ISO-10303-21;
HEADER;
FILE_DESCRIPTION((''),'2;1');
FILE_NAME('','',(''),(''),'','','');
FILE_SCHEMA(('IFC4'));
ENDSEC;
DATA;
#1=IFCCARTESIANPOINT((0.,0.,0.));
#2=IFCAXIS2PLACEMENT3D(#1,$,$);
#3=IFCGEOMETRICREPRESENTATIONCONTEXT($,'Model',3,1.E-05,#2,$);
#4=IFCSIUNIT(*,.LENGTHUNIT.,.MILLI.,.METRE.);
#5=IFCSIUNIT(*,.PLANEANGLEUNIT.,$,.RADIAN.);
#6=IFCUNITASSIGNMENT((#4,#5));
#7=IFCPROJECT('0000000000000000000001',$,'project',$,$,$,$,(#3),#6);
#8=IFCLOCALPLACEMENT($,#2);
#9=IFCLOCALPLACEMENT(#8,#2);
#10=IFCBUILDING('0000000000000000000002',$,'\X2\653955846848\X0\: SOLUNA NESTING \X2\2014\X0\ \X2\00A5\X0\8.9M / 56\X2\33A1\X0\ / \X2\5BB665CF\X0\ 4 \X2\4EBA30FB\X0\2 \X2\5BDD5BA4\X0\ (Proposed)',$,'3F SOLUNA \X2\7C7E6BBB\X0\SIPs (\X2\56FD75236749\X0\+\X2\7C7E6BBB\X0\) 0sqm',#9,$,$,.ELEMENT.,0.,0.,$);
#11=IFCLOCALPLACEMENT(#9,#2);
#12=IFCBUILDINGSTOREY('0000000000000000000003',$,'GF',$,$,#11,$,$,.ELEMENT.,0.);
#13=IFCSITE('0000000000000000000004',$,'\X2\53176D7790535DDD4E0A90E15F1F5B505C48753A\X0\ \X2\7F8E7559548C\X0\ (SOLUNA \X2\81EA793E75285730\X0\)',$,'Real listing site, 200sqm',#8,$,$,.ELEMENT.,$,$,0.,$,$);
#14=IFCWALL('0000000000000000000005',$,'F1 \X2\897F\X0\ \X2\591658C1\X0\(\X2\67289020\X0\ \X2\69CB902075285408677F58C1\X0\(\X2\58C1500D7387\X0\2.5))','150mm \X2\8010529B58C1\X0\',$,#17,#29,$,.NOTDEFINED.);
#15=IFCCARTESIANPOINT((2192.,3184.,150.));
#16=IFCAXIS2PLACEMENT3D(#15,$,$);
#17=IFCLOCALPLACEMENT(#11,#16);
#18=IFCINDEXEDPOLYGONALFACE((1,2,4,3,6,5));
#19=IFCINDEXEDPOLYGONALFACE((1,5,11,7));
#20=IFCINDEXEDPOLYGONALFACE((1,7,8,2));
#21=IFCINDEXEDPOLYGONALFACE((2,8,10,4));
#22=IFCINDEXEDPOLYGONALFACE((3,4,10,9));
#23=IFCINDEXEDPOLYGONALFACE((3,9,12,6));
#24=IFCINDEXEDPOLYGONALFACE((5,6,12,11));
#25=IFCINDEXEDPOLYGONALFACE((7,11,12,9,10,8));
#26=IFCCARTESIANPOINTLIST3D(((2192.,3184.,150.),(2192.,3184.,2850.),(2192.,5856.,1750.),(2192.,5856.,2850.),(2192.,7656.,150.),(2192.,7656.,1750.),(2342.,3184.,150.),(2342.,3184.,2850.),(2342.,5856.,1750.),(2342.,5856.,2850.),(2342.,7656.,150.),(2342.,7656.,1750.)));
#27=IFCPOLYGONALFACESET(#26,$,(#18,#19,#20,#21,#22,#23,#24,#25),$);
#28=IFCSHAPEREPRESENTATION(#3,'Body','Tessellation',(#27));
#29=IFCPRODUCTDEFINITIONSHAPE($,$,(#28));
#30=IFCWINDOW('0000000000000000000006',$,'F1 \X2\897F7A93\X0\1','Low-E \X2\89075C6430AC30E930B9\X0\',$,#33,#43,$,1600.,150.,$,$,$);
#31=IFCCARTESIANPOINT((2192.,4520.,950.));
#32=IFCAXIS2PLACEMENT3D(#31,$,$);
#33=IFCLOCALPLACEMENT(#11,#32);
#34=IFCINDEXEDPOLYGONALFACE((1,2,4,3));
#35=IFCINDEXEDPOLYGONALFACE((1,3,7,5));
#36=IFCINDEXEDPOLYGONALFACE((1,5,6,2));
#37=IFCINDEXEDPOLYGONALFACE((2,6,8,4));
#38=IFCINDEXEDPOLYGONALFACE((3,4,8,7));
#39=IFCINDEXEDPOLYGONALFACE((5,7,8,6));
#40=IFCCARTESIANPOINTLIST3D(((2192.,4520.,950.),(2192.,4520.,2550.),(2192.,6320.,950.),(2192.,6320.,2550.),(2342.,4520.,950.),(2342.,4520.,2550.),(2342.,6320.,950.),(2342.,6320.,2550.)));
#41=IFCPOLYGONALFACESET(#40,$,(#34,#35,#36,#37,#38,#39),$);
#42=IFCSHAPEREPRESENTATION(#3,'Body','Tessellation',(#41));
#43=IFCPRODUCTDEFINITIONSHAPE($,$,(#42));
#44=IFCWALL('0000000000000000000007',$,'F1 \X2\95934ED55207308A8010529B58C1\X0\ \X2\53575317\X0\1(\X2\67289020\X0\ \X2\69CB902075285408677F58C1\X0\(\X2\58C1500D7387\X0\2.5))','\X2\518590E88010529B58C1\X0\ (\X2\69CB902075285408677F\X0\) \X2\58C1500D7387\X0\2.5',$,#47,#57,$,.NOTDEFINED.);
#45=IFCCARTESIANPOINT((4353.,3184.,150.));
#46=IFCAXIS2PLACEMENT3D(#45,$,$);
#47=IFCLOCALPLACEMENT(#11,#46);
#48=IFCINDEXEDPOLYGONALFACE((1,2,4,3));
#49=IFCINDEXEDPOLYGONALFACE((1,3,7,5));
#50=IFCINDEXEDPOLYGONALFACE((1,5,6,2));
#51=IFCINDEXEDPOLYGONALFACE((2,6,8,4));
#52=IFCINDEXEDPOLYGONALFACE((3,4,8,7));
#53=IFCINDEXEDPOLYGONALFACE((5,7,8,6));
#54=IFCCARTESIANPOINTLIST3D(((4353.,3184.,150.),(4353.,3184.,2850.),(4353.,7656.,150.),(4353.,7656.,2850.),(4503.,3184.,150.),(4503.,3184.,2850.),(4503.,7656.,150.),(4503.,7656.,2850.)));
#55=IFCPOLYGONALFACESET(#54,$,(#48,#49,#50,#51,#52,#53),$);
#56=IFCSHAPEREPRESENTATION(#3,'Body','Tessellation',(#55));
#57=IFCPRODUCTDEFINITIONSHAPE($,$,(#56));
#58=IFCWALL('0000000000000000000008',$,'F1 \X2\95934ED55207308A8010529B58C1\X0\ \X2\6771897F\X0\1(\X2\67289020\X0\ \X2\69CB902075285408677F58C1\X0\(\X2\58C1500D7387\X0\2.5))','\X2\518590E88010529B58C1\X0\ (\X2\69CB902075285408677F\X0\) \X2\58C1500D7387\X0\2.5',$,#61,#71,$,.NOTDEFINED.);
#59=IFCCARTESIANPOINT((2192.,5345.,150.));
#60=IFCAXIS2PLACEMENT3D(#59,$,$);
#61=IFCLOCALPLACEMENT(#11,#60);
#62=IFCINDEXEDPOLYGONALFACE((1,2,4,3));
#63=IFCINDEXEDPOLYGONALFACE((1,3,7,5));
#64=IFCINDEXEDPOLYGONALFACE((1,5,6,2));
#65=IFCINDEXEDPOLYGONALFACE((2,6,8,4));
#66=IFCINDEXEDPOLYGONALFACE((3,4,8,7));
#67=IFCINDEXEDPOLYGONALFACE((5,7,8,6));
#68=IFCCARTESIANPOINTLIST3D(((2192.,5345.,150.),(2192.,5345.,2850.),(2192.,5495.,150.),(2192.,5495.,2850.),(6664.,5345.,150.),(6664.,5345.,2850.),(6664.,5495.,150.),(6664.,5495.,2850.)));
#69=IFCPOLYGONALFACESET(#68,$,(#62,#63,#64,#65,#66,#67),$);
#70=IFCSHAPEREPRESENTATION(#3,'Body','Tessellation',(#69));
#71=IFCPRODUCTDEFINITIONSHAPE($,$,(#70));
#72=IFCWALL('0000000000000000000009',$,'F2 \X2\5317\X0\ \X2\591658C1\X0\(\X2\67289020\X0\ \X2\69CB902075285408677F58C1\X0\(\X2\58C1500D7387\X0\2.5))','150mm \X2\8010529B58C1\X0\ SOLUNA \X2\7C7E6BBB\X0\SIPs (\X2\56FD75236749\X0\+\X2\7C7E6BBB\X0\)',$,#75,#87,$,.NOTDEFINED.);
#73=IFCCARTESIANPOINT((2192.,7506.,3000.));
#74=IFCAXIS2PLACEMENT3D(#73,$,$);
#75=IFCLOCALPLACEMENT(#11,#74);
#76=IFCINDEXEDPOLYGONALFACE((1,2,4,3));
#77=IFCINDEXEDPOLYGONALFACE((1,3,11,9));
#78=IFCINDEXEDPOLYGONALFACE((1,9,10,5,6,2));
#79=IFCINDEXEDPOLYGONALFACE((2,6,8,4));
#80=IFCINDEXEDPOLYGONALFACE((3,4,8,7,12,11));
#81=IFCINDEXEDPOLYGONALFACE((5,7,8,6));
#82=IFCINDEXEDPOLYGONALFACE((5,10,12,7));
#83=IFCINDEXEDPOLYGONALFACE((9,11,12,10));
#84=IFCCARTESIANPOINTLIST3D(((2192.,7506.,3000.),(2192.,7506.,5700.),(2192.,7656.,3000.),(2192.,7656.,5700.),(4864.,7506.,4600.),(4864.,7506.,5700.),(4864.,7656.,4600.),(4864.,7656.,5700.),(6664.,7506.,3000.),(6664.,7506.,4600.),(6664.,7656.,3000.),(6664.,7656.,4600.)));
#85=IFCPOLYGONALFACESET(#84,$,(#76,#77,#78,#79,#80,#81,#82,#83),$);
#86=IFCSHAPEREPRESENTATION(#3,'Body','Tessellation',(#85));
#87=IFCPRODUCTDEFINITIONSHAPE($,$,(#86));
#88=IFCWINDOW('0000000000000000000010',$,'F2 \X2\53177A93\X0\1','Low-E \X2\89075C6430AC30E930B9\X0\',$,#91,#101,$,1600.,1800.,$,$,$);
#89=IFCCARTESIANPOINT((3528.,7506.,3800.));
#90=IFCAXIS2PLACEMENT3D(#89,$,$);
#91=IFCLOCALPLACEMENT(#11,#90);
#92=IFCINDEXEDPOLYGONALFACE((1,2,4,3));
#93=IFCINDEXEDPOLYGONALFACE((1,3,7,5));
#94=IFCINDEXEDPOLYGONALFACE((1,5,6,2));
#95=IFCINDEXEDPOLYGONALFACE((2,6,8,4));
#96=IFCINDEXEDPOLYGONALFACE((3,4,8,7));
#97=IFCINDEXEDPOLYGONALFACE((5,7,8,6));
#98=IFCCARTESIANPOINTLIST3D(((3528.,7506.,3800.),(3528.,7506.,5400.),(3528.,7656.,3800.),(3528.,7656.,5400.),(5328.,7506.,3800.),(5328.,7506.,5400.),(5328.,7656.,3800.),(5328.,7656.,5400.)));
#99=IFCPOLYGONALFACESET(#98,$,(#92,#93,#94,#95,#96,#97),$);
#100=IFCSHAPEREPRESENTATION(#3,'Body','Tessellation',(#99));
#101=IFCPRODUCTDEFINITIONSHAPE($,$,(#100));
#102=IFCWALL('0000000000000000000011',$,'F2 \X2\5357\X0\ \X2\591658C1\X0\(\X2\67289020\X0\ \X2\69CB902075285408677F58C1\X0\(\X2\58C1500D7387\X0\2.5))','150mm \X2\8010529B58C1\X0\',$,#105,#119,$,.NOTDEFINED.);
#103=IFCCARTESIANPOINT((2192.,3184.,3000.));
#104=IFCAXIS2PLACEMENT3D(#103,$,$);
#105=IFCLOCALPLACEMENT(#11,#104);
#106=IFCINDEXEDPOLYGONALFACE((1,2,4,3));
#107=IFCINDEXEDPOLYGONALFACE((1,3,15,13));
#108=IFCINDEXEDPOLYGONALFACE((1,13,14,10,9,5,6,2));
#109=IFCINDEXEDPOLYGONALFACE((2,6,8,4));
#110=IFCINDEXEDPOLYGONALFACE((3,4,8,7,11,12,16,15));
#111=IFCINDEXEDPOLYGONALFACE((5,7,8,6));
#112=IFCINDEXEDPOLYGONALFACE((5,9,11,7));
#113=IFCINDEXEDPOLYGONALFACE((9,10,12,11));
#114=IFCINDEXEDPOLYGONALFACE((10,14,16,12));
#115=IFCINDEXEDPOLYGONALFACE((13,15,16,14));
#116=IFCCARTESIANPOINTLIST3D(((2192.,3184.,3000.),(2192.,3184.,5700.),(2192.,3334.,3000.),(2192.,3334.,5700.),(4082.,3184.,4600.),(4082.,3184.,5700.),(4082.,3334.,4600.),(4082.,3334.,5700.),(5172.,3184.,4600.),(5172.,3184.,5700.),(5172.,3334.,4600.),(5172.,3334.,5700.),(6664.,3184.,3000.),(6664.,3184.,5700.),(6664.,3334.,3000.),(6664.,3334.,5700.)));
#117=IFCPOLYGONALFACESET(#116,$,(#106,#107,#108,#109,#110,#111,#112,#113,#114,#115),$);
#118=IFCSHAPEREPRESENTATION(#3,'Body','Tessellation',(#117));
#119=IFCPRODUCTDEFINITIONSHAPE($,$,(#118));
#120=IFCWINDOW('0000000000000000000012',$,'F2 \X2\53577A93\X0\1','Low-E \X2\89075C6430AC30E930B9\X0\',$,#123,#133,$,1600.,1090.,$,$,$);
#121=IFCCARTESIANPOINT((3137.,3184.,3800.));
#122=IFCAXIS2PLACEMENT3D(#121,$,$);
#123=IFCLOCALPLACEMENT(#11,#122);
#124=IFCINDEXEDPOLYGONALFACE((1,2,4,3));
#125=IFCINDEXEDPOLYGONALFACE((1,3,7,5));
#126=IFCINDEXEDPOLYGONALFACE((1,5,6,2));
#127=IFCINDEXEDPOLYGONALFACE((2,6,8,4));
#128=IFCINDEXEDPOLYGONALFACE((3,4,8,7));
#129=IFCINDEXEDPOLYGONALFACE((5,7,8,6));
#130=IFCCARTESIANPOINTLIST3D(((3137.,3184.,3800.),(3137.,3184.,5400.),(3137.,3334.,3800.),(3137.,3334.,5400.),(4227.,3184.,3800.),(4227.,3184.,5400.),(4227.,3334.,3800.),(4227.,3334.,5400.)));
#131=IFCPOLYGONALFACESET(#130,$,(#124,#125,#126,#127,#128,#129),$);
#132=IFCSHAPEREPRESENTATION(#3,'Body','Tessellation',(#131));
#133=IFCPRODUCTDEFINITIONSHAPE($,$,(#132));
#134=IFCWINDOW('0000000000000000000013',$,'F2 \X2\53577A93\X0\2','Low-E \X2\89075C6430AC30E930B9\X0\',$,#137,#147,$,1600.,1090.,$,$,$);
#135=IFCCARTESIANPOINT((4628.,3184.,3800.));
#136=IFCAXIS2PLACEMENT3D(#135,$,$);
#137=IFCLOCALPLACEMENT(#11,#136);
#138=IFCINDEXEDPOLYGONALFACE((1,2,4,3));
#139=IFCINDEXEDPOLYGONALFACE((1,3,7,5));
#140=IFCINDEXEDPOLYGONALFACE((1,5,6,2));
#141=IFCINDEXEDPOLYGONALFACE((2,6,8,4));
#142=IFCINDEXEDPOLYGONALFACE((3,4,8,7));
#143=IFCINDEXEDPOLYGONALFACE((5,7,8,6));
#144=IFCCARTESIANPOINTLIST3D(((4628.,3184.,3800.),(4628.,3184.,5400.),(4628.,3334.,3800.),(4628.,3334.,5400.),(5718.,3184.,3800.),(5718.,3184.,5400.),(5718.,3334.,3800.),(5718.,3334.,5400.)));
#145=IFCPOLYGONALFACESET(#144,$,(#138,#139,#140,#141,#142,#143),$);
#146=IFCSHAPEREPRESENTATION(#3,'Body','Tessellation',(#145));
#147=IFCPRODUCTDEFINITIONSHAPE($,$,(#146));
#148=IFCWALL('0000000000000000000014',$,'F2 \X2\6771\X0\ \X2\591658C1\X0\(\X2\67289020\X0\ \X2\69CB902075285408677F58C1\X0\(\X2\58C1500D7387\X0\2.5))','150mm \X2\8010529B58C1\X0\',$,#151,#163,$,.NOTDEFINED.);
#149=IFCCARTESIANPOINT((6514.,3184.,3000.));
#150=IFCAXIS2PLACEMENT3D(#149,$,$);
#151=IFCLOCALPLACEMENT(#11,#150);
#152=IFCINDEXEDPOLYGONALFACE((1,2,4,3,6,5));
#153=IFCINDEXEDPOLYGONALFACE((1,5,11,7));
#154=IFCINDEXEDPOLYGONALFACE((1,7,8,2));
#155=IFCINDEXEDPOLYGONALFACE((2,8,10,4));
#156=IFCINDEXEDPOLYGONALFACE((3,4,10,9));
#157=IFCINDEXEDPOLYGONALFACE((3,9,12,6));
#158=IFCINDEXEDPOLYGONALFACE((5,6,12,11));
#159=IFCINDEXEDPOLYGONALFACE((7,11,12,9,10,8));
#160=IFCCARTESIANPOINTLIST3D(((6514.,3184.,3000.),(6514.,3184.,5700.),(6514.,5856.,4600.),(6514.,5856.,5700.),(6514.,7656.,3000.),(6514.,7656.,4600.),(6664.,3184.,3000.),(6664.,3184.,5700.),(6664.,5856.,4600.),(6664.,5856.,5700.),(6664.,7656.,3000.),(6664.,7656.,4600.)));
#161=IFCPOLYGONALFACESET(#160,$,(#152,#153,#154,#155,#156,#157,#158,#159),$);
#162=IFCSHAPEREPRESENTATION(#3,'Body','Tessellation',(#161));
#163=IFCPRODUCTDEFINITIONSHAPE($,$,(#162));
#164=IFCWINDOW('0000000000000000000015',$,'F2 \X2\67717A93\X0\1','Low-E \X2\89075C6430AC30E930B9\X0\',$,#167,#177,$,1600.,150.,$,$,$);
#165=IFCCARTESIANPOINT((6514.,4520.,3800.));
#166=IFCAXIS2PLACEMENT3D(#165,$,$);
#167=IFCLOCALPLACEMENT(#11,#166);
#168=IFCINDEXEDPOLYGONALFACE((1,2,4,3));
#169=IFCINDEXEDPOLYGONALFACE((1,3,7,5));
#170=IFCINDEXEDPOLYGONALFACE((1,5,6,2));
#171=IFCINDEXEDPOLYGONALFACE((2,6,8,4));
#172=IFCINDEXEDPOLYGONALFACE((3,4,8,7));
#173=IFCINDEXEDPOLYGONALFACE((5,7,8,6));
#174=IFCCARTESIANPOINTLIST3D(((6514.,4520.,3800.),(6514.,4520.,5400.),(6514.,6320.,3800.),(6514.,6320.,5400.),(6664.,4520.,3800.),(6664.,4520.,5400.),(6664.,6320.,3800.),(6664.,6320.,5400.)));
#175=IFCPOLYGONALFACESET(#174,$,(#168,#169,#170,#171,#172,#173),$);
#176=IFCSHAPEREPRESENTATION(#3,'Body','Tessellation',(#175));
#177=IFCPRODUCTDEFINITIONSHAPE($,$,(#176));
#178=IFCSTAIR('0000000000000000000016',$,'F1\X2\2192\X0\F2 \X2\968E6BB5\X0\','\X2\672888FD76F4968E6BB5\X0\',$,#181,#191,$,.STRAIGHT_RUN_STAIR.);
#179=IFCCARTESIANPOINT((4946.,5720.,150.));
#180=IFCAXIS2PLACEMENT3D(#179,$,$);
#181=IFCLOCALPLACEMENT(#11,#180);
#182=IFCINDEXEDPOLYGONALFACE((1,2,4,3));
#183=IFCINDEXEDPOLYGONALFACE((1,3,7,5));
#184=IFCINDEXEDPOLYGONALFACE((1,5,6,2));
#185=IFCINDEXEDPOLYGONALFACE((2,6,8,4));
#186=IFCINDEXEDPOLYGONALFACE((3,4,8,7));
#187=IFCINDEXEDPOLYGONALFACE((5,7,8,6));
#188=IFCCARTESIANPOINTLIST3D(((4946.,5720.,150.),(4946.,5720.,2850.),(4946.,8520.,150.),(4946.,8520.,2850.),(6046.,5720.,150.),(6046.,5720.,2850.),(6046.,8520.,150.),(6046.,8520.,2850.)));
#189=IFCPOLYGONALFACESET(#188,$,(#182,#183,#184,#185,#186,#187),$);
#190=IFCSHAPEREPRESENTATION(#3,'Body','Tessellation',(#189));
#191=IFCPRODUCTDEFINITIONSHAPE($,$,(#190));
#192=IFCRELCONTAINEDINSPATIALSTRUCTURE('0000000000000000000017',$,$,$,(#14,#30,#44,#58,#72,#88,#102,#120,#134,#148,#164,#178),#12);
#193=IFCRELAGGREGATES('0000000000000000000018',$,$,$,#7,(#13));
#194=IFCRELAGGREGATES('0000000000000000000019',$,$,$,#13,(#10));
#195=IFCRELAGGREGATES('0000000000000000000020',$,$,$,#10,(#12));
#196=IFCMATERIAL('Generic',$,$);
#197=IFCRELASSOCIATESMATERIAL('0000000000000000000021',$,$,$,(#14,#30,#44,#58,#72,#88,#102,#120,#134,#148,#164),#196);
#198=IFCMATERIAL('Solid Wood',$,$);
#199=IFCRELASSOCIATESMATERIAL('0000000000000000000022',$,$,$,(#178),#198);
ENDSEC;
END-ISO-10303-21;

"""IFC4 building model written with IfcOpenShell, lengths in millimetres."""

from ifc_helpers import new_model, si_unit, frame, frame_2d, origin, place, context, project, spatial, rectangle, extrude, material, element, fill, save


model = new_model("IFC4")

# Units and contexts
model_context = context("Model", 3, precision=1e-05, world=origin())
ifc_project = project(units=[si_unit("LENGTHUNIT", "METRE", prefix="MILLI"), si_unit("PLANEANGLEUNIT", "RADIAN")], contexts=[model_context])

# Site, building, storey
site_placement = place(None, origin())
site = spatial("IfcSite", under=ifc_project, at=site_placement, Name="北海道川上郡弟子屈町 美留和 (SOLUNA 自社用地)", ObjectType="Real listing site, 200sqm", CompositionType="ELEMENT", RefElevation=0.0)
building_placement = place(site_placement, origin())
building = spatial("IfcBuilding", under=site, at=building_placement, Name="改善案: SOLUNA NESTING — ¥8.9M / 56㎡ / 家族 4 人・2 寝室 (Proposed)", ObjectType="3F SOLUNA 籾殻SIPs (国産杉+籾殻) 0sqm", CompositionType="ELEMENT", ElevationOfRefHeight=0.0, ElevationOfTerrain=0.0)
storey_placement = place(building_placement, origin())
storey = spatial("IfcBuildingStorey", under=building, at=storey_placement, Name="GF", CompositionType="ELEMENT", Elevation=0.0)

# Shared definitions
ifc_material_1 = material(Name="Generic")

# Shared definitions
ifc_material_2 = material(Name="Solid Wood")

# Wall, opening, window
wall_1_placement = place(storey_placement, frame((2192.0, 3184.0, 150.0)))
wall_1 = element("IfcWall", 1, at=wall_1_placement, inside=storey, material=ifc_material_1, Name="F1 西 外壁(木造 構造用合板壁(壁倍率2.5))", Description="150mm 耐力壁", PredefinedType="NOTDEFINED", context=model_context, shape_type="SweptSolid", body=[
    extrude(rectangle(XDim=150.0, YDim=4472.0, at=frame_2d((75.0, 2236.0))), frame((2192.0, 3184.0, 150.0)), (0.0, 0.0, 1.0), 2700.0),
])
opening_1_placement = place(storey_placement, frame((2192.0, 4520.0, 950.0)))
opening_1 = element("IfcOpeningElement", 2, at=opening_1_placement, cuts=wall_1, PredefinedType="NOTDEFINED", context=model_context, shape_type="SweptSolid", body=[
    extrude(rectangle(XDim=150.0, YDim=1800.0, at=frame_2d((75.0, 900.0))), frame((2192.0, 4520.0, 950.0)), (0.0, 0.0, 1.0), 1600.0),
])
window_1_placement = place(storey_placement, frame((2192.0, 4520.0, 950.0)))
window_1 = element("IfcWindow", 3, at=window_1_placement, inside=storey, material=ifc_material_1, Name="F1 西窓1", Description="Low-E 複層ガラス", OverallHeight=1600.0, OverallWidth=150.0, context=model_context, shape_type="SweptSolid", body=[
    extrude(rectangle(XDim=150.0, YDim=1800.0, at=frame_2d((75.0, 900.0))), frame((2192.0, 4520.0, 950.0)), (0.0, 0.0, 1.0), 1600.0),
])
fill(opening_1, window_1)

# Walls
wall_2_placement = place(storey_placement, frame((4353.0, 3184.0, 150.0)))
element("IfcWall", 4, at=wall_2_placement, inside=storey, material=ifc_material_1, Name="F1 間仕切り耐力壁 南北1(木造 構造用合板壁(壁倍率2.5))", Description="内部耐力壁 (構造用合板) 壁倍率2.5", PredefinedType="NOTDEFINED", context=model_context, shape_type="SweptSolid", body=[
    extrude(rectangle(XDim=150.0, YDim=4472.0, at=frame_2d((75.0, 2236.0))), frame((4353.0, 3184.0, 150.0)), (0.0, 0.0, 1.0), 2700.0),
])
wall_3_placement = place(storey_placement, frame((2192.0, 5345.0, 150.0)))
element("IfcWall", 5, at=wall_3_placement, inside=storey, material=ifc_material_1, Name="F1 間仕切り耐力壁 東西1(木造 構造用合板壁(壁倍率2.5))", Description="内部耐力壁 (構造用合板) 壁倍率2.5", PredefinedType="NOTDEFINED", context=model_context, shape_type="SweptSolid", body=[
    extrude(rectangle(XDim=4472.0, YDim=150.0, at=frame_2d((2236.0, 75.0))), frame((2192.0, 5345.0, 150.0)), (0.0, 0.0, 1.0), 2700.0),
])

# Wall, opening, window
wall_4_placement = place(storey_placement, frame((2192.0, 7506.0, 3000.0)))
wall_4 = element("IfcWall", 6, at=wall_4_placement, inside=storey, material=ifc_material_1, Name="F2 北 外壁(木造 構造用合板壁(壁倍率2.5))", Description="150mm 耐力壁 SOLUNA 籾殻SIPs (国産杉+籾殻)", PredefinedType="NOTDEFINED", context=model_context, shape_type="SweptSolid", body=[
    extrude(rectangle(XDim=4472.0, YDim=150.0, at=frame_2d((2236.0, 75.0))), frame((2192.0, 7506.0, 3000.0)), (0.0, 0.0, 1.0), 2700.0),
])
opening_2_placement = place(storey_placement, frame((3528.0, 7506.0, 3800.0)))
opening_2 = element("IfcOpeningElement", 7, at=opening_2_placement, cuts=wall_4, PredefinedType="NOTDEFINED", context=model_context, shape_type="SweptSolid", body=[
    extrude(rectangle(XDim=1800.0, YDim=150.0, at=frame_2d((900.0, 75.0))), frame((3528.0, 7506.0, 3800.0)), (0.0, 0.0, 1.0), 1600.0),
])
window_2_placement = place(storey_placement, frame((3528.0, 7506.0, 3800.0)))
window_2 = element("IfcWindow", 8, at=window_2_placement, inside=storey, material=ifc_material_1, Name="F2 北窓1", Description="Low-E 複層ガラス", OverallHeight=1600.0, OverallWidth=1800.0, context=model_context, shape_type="SweptSolid", body=[
    extrude(rectangle(XDim=1800.0, YDim=150.0, at=frame_2d((900.0, 75.0))), frame((3528.0, 7506.0, 3800.0)), (0.0, 0.0, 1.0), 1600.0),
])
fill(opening_2, window_2)

# Wall, openings, windows
wall_5_placement = place(storey_placement, frame((2192.0, 3184.0, 3000.0)))
wall_5 = element("IfcWall", 9, at=wall_5_placement, inside=storey, material=ifc_material_1, Name="F2 南 外壁(木造 構造用合板壁(壁倍率2.5))", Description="150mm 耐力壁", PredefinedType="NOTDEFINED", context=model_context, shape_type="SweptSolid", body=[
    extrude(rectangle(XDim=4472.0, YDim=150.0, at=frame_2d((2236.0, 75.0))), frame((2192.0, 3184.0, 3000.0)), (0.0, 0.0, 1.0), 2700.0),
])
opening_3_placement = place(storey_placement, frame((3137.0, 3184.0, 3800.0)))
opening_3 = element("IfcOpeningElement", 10, at=opening_3_placement, cuts=wall_5, PredefinedType="NOTDEFINED", context=model_context, shape_type="SweptSolid", body=[
    extrude(rectangle(XDim=1090.0, YDim=150.0, at=frame_2d((545.0, 75.0))), frame((3137.0, 3184.0, 3800.0)), (0.0, 0.0, 1.0), 1600.0),
])
opening_4_placement = place(storey_placement, frame((4628.0, 3184.0, 3800.0)))
opening_4 = element("IfcOpeningElement", 11, at=opening_4_placement, cuts=wall_5, PredefinedType="NOTDEFINED", context=model_context, shape_type="SweptSolid", body=[
    extrude(rectangle(XDim=1090.0, YDim=150.0, at=frame_2d((545.0, 75.0))), frame((4628.0, 3184.0, 3800.0)), (0.0, 0.0, 1.0), 1600.0),
])
window_3_placement = place(storey_placement, frame((3137.0, 3184.0, 3800.0)))
window_3 = element("IfcWindow", 12, at=window_3_placement, inside=storey, material=ifc_material_1, Name="F2 南窓1", Description="Low-E 複層ガラス", OverallHeight=1600.0, OverallWidth=1090.0, context=model_context, shape_type="SweptSolid", body=[
    extrude(rectangle(XDim=1090.0, YDim=150.0, at=frame_2d((545.0, 75.0))), frame((3137.0, 3184.0, 3800.0)), (0.0, 0.0, 1.0), 1600.0),
])
fill(opening_3, window_3)
window_4_placement = place(storey_placement, frame((4628.0, 3184.0, 3800.0)))
window_4 = element("IfcWindow", 13, at=window_4_placement, inside=storey, material=ifc_material_1, Name="F2 南窓2", Description="Low-E 複層ガラス", OverallHeight=1600.0, OverallWidth=1090.0, context=model_context, shape_type="SweptSolid", body=[
    extrude(rectangle(XDim=1090.0, YDim=150.0, at=frame_2d((545.0, 75.0))), frame((4628.0, 3184.0, 3800.0)), (0.0, 0.0, 1.0), 1600.0),
])
fill(opening_4, window_4)

# Wall, opening, window
wall_6_placement = place(storey_placement, frame((6514.0, 3184.0, 3000.0)))
wall_6 = element("IfcWall", 14, at=wall_6_placement, inside=storey, material=ifc_material_1, Name="F2 東 外壁(木造 構造用合板壁(壁倍率2.5))", Description="150mm 耐力壁", PredefinedType="NOTDEFINED", context=model_context, shape_type="SweptSolid", body=[
    extrude(rectangle(XDim=150.0, YDim=4472.0, at=frame_2d((75.0, 2236.0))), frame((6514.0, 3184.0, 3000.0)), (0.0, 0.0, 1.0), 2700.0),
])
opening_5_placement = place(storey_placement, frame((6514.0, 4520.0, 3800.0)))
opening_5 = element("IfcOpeningElement", 15, at=opening_5_placement, cuts=wall_6, PredefinedType="NOTDEFINED", context=model_context, shape_type="SweptSolid", body=[
    extrude(rectangle(XDim=150.0, YDim=1800.0, at=frame_2d((75.0, 900.0))), frame((6514.0, 4520.0, 3800.0)), (0.0, 0.0, 1.0), 1600.0),
])
window_5_placement = place(storey_placement, frame((6514.0, 4520.0, 3800.0)))
window_5 = element("IfcWindow", 16, at=window_5_placement, inside=storey, material=ifc_material_1, Name="F2 東窓1", Description="Low-E 複層ガラス", OverallHeight=1600.0, OverallWidth=150.0, context=model_context, shape_type="SweptSolid", body=[
    extrude(rectangle(XDim=150.0, YDim=1800.0, at=frame_2d((75.0, 900.0))), frame((6514.0, 4520.0, 3800.0)), (0.0, 0.0, 1.0), 1600.0),
])
fill(opening_5, window_5)

# Stair
stair_placement = place(storey_placement, frame((4946.0, 5720.0, 150.0)))
element("IfcStair", 17, at=stair_placement, inside=storey, material=ifc_material_2, Name="F1→F2 階段", Description="木製直階段", PredefinedType="STRAIGHT_RUN_STAIR", context=model_context, shape_type="SweptSolid", body=[
    extrude(rectangle(XDim=1100.0, YDim=2800.0, at=frame_2d((550.0, 1400.0))), frame((4946.0, 5720.0, 150.0)), (0.0, 0.0, 1.0), 2700.0),
])

save(model, "model.ifc")
